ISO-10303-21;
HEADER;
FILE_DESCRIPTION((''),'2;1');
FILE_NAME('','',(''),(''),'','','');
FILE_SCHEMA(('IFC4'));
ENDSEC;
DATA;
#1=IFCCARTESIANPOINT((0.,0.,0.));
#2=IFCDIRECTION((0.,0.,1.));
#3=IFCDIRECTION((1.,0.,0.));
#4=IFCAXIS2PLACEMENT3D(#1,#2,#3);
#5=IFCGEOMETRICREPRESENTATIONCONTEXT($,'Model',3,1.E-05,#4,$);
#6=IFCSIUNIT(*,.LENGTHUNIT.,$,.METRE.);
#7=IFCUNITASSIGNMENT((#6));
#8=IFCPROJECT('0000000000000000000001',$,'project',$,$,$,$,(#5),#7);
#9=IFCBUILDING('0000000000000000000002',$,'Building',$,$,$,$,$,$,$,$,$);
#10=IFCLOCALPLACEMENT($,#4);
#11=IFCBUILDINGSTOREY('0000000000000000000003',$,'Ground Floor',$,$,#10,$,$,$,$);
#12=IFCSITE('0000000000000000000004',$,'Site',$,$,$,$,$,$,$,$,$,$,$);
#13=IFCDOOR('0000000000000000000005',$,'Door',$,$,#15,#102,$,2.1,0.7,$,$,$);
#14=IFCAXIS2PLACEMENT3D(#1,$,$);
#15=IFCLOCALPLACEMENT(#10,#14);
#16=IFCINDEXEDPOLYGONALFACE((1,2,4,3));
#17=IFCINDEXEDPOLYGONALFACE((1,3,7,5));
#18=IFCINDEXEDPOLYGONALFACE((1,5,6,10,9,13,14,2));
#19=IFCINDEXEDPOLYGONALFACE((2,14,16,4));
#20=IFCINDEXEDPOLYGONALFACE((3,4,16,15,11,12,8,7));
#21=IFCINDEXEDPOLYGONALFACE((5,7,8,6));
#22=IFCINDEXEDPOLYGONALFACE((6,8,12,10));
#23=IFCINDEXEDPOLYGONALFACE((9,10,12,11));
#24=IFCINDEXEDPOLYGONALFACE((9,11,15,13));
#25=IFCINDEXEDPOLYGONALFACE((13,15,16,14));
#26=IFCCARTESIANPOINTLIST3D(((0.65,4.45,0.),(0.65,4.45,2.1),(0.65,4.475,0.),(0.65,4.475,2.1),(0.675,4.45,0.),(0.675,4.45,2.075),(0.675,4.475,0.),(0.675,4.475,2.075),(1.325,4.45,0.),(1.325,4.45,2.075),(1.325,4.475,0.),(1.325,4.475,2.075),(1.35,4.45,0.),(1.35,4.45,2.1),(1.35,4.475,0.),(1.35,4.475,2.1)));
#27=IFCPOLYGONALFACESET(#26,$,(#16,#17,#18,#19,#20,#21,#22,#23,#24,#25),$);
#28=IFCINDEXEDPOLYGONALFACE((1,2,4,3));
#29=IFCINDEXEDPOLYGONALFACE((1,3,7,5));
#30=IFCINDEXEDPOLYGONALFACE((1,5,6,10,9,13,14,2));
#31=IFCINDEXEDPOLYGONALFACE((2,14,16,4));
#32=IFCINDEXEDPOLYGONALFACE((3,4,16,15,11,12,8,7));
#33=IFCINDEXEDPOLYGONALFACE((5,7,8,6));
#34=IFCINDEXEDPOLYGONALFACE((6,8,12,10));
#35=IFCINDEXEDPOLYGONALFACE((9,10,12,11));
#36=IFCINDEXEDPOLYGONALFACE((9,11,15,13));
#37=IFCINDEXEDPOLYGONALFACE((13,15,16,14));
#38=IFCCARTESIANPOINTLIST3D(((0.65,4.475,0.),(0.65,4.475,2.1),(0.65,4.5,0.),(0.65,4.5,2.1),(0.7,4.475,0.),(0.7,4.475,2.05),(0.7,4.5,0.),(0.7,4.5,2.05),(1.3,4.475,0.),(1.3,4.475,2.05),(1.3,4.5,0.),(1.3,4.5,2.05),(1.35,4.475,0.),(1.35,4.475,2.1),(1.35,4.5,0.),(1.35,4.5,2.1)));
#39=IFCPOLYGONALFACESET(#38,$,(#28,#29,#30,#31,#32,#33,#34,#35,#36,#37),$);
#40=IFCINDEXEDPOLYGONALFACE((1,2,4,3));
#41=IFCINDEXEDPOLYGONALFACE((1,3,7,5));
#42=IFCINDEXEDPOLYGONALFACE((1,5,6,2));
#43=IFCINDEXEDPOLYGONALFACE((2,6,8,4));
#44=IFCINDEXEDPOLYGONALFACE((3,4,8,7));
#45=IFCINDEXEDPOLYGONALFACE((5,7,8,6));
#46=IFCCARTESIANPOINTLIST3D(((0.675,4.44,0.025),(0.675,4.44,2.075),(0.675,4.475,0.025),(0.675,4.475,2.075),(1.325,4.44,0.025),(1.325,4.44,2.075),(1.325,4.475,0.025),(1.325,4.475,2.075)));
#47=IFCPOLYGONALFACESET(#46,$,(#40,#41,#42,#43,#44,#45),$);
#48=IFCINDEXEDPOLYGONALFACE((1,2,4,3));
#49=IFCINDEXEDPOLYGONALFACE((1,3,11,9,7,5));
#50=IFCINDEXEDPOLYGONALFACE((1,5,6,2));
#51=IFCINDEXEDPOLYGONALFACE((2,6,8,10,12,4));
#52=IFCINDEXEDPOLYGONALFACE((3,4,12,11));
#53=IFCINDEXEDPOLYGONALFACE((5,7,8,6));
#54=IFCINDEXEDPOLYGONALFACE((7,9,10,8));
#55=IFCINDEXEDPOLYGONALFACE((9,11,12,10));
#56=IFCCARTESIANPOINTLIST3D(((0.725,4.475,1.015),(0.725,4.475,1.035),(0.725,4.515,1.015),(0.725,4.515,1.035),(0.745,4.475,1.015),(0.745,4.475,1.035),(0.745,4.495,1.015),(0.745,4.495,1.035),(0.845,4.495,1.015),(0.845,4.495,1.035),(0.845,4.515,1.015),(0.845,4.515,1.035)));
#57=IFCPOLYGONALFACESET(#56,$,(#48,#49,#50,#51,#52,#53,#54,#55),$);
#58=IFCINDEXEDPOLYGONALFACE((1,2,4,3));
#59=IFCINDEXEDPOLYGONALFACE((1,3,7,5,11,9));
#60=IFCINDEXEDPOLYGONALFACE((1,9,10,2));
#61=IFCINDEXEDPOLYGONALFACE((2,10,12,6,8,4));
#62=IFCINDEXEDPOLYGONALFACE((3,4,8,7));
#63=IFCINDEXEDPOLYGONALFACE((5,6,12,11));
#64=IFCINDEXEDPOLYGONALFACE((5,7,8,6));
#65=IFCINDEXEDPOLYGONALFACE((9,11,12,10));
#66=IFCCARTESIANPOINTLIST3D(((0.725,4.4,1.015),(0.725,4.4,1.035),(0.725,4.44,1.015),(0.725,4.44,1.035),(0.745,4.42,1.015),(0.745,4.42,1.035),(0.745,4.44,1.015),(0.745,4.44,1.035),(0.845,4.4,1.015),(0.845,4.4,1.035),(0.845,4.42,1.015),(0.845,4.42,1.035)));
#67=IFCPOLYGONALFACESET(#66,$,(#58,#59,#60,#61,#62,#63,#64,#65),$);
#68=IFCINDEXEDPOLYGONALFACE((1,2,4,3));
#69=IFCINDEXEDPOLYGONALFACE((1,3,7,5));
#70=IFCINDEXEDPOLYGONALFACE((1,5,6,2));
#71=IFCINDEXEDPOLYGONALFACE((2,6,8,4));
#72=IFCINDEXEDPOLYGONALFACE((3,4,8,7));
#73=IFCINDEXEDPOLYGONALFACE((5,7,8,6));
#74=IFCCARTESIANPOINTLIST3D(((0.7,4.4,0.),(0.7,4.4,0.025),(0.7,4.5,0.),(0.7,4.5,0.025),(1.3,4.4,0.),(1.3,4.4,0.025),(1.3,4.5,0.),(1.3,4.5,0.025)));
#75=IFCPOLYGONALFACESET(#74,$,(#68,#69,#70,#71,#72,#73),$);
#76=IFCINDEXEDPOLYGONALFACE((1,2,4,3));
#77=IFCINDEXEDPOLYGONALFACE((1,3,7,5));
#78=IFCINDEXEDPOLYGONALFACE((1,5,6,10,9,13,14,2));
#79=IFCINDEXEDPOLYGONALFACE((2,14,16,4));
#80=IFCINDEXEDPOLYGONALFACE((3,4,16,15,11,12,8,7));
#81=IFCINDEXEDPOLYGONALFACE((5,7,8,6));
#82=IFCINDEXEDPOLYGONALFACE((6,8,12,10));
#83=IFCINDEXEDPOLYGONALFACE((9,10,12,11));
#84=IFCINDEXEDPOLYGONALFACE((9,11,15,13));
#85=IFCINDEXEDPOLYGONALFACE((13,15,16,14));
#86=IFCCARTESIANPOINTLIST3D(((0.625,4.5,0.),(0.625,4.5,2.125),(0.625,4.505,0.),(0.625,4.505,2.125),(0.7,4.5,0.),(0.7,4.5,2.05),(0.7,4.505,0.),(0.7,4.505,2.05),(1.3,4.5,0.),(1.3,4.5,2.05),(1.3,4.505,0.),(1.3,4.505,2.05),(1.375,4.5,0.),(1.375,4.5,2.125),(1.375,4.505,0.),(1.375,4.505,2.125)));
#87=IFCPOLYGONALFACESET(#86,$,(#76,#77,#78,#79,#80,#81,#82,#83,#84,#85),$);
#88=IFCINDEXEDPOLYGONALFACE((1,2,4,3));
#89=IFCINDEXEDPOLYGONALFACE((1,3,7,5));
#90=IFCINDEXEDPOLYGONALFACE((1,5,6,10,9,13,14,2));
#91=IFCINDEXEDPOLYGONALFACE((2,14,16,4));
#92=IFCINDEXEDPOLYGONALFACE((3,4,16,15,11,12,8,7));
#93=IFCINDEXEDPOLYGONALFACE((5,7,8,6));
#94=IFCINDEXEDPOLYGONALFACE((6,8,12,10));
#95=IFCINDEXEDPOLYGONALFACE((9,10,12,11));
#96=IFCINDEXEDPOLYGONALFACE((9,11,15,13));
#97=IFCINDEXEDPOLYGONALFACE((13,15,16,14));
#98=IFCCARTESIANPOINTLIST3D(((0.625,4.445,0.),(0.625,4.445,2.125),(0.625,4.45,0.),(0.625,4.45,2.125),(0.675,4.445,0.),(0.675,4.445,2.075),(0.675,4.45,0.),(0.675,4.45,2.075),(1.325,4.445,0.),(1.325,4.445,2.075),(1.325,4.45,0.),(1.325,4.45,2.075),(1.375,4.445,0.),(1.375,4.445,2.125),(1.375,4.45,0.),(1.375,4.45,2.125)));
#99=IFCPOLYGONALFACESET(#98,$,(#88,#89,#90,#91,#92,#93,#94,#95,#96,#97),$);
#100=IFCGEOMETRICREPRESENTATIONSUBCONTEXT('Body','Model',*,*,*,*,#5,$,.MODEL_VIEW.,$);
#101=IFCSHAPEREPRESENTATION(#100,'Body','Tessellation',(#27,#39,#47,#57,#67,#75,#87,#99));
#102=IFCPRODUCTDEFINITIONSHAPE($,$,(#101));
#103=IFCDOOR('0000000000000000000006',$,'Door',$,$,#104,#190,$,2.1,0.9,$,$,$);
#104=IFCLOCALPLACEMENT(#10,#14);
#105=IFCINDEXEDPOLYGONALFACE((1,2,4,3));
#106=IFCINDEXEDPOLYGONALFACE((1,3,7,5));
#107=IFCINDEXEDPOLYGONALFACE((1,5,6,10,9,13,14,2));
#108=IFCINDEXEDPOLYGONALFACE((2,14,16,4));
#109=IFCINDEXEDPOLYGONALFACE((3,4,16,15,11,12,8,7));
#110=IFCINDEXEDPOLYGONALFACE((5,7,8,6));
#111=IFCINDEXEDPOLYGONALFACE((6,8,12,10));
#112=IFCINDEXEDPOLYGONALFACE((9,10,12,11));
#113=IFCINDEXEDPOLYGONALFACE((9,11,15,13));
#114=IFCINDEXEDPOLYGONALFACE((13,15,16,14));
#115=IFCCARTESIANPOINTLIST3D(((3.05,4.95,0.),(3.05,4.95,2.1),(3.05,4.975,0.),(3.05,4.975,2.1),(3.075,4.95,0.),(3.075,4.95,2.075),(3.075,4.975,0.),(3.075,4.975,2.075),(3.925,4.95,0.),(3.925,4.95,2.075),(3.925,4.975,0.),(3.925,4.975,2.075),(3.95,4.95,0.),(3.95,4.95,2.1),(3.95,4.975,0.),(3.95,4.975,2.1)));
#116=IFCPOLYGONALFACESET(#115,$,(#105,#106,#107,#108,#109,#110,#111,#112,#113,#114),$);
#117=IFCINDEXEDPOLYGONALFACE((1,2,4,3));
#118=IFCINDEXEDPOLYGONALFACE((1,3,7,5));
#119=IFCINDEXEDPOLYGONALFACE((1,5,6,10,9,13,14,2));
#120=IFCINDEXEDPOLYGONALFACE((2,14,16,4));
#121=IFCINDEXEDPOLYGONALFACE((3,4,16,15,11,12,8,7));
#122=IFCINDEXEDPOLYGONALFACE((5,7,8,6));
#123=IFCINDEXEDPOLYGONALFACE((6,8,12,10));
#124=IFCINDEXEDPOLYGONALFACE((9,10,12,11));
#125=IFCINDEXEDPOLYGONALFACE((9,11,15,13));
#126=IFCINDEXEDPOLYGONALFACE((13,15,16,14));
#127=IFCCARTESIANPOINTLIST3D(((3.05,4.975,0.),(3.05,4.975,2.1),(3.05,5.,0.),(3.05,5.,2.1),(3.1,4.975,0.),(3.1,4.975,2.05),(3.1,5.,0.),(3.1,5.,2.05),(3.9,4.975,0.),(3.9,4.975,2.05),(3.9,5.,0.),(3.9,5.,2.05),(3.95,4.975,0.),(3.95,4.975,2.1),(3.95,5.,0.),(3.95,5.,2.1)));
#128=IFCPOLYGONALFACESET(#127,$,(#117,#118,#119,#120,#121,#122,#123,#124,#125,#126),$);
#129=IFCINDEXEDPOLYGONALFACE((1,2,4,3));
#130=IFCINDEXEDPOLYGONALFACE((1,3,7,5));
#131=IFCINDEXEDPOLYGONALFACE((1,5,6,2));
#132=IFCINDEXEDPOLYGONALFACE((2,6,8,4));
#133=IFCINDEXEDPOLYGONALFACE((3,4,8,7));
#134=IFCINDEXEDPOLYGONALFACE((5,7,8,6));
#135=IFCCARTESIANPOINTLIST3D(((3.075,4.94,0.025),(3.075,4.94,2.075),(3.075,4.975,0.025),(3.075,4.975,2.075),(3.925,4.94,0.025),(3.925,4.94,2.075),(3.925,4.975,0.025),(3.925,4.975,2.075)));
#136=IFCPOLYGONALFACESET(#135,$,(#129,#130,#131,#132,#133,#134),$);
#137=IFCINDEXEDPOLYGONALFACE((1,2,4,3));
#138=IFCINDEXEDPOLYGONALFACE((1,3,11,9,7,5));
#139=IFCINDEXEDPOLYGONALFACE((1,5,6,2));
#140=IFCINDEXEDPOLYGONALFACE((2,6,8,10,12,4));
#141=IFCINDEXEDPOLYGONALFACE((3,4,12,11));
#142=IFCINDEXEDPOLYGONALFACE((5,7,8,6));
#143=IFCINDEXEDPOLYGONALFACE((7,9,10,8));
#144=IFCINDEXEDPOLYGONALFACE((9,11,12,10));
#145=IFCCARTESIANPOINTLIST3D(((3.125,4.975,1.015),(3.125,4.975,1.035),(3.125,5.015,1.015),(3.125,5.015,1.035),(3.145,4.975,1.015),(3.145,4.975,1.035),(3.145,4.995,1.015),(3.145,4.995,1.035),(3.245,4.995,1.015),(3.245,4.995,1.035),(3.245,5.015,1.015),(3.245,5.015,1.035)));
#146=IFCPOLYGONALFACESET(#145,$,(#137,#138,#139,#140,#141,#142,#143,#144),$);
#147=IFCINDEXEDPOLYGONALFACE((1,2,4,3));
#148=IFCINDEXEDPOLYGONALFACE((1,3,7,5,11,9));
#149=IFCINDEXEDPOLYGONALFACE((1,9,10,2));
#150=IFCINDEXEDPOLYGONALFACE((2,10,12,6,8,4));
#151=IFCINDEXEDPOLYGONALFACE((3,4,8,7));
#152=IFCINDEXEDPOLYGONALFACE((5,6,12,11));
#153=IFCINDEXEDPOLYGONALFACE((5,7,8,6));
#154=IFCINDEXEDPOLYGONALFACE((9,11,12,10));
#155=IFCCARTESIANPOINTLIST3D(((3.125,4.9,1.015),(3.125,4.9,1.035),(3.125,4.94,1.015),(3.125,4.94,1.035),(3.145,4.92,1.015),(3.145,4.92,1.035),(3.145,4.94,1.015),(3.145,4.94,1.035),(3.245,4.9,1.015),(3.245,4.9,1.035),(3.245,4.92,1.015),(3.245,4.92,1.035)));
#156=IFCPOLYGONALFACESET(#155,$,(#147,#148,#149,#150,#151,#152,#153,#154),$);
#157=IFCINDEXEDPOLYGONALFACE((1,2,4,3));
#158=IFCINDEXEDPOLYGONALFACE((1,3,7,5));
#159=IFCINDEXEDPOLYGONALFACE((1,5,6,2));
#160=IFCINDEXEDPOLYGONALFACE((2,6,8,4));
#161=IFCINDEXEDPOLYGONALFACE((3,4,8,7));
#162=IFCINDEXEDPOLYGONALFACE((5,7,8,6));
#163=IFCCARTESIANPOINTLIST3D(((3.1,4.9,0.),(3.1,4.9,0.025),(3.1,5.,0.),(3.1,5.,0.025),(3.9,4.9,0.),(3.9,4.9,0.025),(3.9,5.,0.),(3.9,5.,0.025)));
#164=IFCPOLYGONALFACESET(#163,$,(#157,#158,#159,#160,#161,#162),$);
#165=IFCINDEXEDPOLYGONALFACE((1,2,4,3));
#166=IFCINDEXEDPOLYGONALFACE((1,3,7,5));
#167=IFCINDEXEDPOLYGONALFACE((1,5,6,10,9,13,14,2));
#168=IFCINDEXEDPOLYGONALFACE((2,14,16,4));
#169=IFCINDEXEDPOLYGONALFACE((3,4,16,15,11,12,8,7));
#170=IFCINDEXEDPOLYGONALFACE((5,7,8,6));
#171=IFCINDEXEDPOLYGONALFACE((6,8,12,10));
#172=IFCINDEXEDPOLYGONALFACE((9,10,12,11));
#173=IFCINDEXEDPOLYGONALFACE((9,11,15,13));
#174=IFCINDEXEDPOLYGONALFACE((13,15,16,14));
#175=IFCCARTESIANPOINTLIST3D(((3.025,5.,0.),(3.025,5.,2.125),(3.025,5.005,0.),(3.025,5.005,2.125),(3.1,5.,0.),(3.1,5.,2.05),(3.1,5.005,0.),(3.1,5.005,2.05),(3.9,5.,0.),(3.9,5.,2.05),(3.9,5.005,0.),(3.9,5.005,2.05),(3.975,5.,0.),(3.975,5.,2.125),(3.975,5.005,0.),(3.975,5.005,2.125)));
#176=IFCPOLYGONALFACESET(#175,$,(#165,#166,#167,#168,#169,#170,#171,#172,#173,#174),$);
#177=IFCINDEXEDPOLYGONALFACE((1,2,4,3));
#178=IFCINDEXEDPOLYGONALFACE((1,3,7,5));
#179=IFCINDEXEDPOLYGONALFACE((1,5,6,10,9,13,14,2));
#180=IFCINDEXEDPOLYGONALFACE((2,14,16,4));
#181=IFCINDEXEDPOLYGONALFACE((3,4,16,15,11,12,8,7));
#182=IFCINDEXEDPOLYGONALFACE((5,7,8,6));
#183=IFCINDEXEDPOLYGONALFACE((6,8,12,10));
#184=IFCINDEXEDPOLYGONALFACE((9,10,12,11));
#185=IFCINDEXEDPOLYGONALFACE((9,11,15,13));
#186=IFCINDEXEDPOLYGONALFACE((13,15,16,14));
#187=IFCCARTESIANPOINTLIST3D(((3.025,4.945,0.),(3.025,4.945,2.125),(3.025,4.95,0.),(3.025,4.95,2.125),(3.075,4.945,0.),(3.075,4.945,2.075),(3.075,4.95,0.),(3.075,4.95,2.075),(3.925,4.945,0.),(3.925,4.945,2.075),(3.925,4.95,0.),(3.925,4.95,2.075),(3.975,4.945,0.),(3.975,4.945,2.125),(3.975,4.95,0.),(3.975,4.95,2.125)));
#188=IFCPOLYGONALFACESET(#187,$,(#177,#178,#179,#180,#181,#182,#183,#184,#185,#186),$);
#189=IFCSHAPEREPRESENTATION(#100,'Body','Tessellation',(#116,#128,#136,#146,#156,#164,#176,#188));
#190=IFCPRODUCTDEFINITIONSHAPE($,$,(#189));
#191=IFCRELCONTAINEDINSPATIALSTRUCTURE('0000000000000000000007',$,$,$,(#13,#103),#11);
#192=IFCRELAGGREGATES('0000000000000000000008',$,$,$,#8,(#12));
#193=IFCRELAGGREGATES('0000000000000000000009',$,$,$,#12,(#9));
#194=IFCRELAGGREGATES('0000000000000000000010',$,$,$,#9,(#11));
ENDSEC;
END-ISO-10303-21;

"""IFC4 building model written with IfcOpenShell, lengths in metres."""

from ifc_helpers import new_model, si_unit, frame, origin_with_axes, place, context, subcontext, project, spatial, line, indexed_curve, outline, extrude, element, save


model = new_model("IFC4")

# Units and contexts
model_context = context("Model", 3, precision=1e-05, world=origin_with_axes())
body_context = subcontext(model_context, "Body", "Model", "MODEL_VIEW")
ifc_project = project(units=[si_unit("LENGTHUNIT", "METRE")], contexts=[model_context])

# Site, building, storey
site = spatial("IfcSite", under=ifc_project, Name="Site")
building = spatial("IfcBuilding", under=site, Name="Building")
storey_placement = place(None, origin_with_axes())
storey = spatial("IfcBuildingStorey", under=building, at=storey_placement, Name="Ground Floor")

# Doors
door_1_placement = place(storey_placement, frame((1.35, 4.5, 0.0), z_axis=(0.0, 0.0, 1.0), x_axis=(-1.0, 0.0, 0.0)))
element("IfcDoor", 1, at=door_1_placement, inside=storey, Name="Door", OverallHeight=2.1, OverallWidth=0.7, context=body_context, shape_type="SweptSolid", body=[
    extrude(outline(indexed_curve([(0.0, 0.0), (0.0, 2.1), (0.7, 2.1), (0.7, 0.0), (0.675, 0.0), (0.675, 2.075), (0.025, 2.075), (0.025, 0.0)], segments=[line(1, 2, 3, 4, 5, 6, 7, 8, 1)])), frame((0.0, 0.025, 0.0), z_axis=(0.0, -1.0, 0.0), x_axis=(1.0, 0.0, 0.0)), (0.0, 0.0, -1.0), 0.025),
    extrude(outline(indexed_curve([(0.0, 0.0), (0.0, 2.1), (0.7, 2.1), (0.7, 0.0), (0.65, 0.0), (0.65, 2.05), (0.05, 2.05), (0.05, 0.0)], segments=[line(1, 2, 3, 4, 5, 6, 7, 8, 1)])), frame((0.0, 0.0, 0.0), z_axis=(0.0, -1.0, 0.0), x_axis=(1.0, 0.0, 0.0)), (0.0, 0.0, -1.0), 0.025),
    extrude(outline(indexed_curve([(0.0, 0.0), (0.65, 0.0), (0.65, 0.035), (0.0, 0.035)], segments=[line(1, 2, 3, 4, 1)])), frame((0.025, 0.025, 0.025), z_axis=(0.0, 0.0, 1.0), x_axis=(1.0, 0.0, 0.0)), (0.0, 0.0, 1.0), 2.05),
    extrude(outline(indexed_curve([(0.0, 0.0), (0.0, -0.04), (-0.12, -0.04), (-0.12, -0.02), (-0.02, -0.02), (-0.02, 0.0)], segments=[line(1, 2, 3, 4, 5, 6, 1)])), frame((0.625, 0.025, 1.015), z_axis=(0.0, 0.0, 1.0), x_axis=(1.0, 0.0, 0.0)), (0.0, 0.0, 1.0), 0.02),
    extrude(outline(indexed_curve([(0.0, 0.0), (0.0, 0.04), (-0.12, 0.04), (-0.12, 0.02), (-0.02, 0.02), (-0.02, 0.0)], segments=[line(1, 2, 3, 4, 5, 6, 1)])), frame((0.625, 0.06, 1.015), z_axis=(0.0, 0.0, 1.0), x_axis=(1.0, 0.0, 0.0)), (0.0, 0.0, 1.0), 0.02),
    extrude(outline(indexed_curve([(0.0, 0.0), (0.6, 0.0), (0.6, 0.1), (0.0, 0.1)], segments=[line(1, 2, 3, 4, 1)])), frame((0.05, 0.0, 0.0), z_axis=(0.0, 0.0, 1.0), x_axis=(1.0, 0.0, 0.0)), (0.0, 0.0, 1.0), 0.025),
    extrude(outline(indexed_curve([(0.0, 0.0), (0.0, 2.125), (0.75, 2.125), (0.75, 0.0), (0.675, 0.0), (0.675, 2.05), (0.075, 2.05), (0.075, 0.0)], segments=[line(1, 2, 3, 4, 5, 6, 7, 8, 1)])), frame((-0.025, -0.005, 0.0), z_axis=(0.0, -1.0, 0.0), x_axis=(1.0, 0.0, 0.0)), (0.0, 0.0, -1.0), 0.005),
    extrude(outline(indexed_curve([(0.0, 0.0), (0.0, 2.125), (0.75, 2.125), (0.75, 0.0), (0.7, 0.0), (0.7, 2.075), (0.05, 2.075), (0.05, 0.0)], segments=[line(1, 2, 3, 4, 5, 6, 7, 8, 1)])), frame((-0.025, 0.05, 0.0), z_axis=(0.0, -1.0, 0.0), x_axis=(1.0, 0.0, 0.0)), (0.0, 0.0, -1.0), 0.005),
])
door_2_placement = place(storey_placement, frame((3.95, 5.0, 0.0), z_axis=(0.0, 0.0, 1.0), x_axis=(-1.0, 0.0, 0.0)))
element("IfcDoor", 2, at=door_2_placement, inside=storey, Name="Door", OverallHeight=2.1, OverallWidth=0.9, context=body_context, shape_type="SweptSolid", body=[
    extrude(outline(indexed_curve([(0.0, 0.0), (0.0, 2.1), (0.9, 2.1), (0.9, 0.0), (0.875, 0.0), (0.875, 2.075), (0.025, 2.075), (0.025, 0.0)], segments=[line(1, 2, 3, 4, 5, 6, 7, 8, 1)])), frame((0.0, 0.025, 0.0), z_axis=(0.0, -1.0, 0.0), x_axis=(1.0, 0.0, 0.0)), (0.0, 0.0, -1.0), 0.025),
    extrude(outline(indexed_curve([(0.0, 0.0), (0.0, 2.1), (0.9, 2.1), (0.9, 0.0), (0.85, 0.0), (0.85, 2.05), (0.05, 2.05), (0.05, 0.0)], segments=[line(1, 2, 3, 4, 5, 6, 7, 8, 1)])), frame((0.0, 0.0, 0.0), z_axis=(0.0, -1.0, 0.0), x_axis=(1.0, 0.0, 0.0)), (0.0, 0.0, -1.0), 0.025),
    extrude(outline(indexed_curve([(0.0, 0.0), (0.85, 0.0), (0.85, 0.035), (0.0, 0.035)], segments=[line(1, 2, 3, 4, 1)])), frame((0.025, 0.025, 0.025), z_axis=(0.0, 0.0, 1.0), x_axis=(1.0, 0.0, 0.0)), (0.0, 0.0, 1.0), 2.05),
    extrude(outline(indexed_curve([(0.0, 0.0), (0.0, -0.04), (-0.12, -0.04), (-0.12, -0.02), (-0.02, -0.02), (-0.02, 0.0)], segments=[line(1, 2, 3, 4, 5, 6, 1)])), frame((0.825, 0.025, 1.015), z_axis=(0.0, 0.0, 1.0), x_axis=(1.0, 0.0, 0.0)), (0.0, 0.0, 1.0), 0.02),
    extrude(outline(indexed_curve([(0.0, 0.0), (0.0, 0.04), (-0.12, 0.04), (-0.12, 0.02), (-0.02, 0.02), (-0.02, 0.0)], segments=[line(1, 2, 3, 4, 5, 6, 1)])), frame((0.825, 0.06, 1.015), z_axis=(0.0, 0.0, 1.0), x_axis=(1.0, 0.0, 0.0)), (0.0, 0.0, 1.0), 0.02),
    extrude(outline(indexed_curve([(0.0, 0.0), (0.8, 0.0), (0.8, 0.1), (0.0, 0.1)], segments=[line(1, 2, 3, 4, 1)])), frame((0.05, 0.0, 0.0), z_axis=(0.0, 0.0, 1.0), x_axis=(1.0, 0.0, 0.0)), (0.0, 0.0, 1.0), 0.025),
    extrude(outline(indexed_curve([(0.0, 0.0), (0.0, 2.125), (0.95, 2.125), (0.95, 0.0), (0.875, 0.0), (0.875, 2.05), (0.075, 2.05), (0.075, 0.0)], segments=[line(1, 2, 3, 4, 5, 6, 7, 8, 1)])), frame((-0.025, -0.005, 0.0), z_axis=(0.0, -1.0, 0.0), x_axis=(1.0, 0.0, 0.0)), (0.0, 0.0, -1.0), 0.005),
    extrude(outline(indexed_curve([(0.0, 0.0), (0.0, 2.125), (0.95, 2.125), (0.95, 0.0), (0.9, 0.0), (0.9, 2.075), (0.05, 2.075), (0.05, 0.0)], segments=[line(1, 2, 3, 4, 5, 6, 7, 8, 1)])), frame((-0.025, 0.05, 0.0), z_axis=(0.0, -1.0, 0.0), x_axis=(1.0, 0.0, 0.0)), (0.0, 0.0, -1.0), 0.005),
])

save(model, "model.ifc")
